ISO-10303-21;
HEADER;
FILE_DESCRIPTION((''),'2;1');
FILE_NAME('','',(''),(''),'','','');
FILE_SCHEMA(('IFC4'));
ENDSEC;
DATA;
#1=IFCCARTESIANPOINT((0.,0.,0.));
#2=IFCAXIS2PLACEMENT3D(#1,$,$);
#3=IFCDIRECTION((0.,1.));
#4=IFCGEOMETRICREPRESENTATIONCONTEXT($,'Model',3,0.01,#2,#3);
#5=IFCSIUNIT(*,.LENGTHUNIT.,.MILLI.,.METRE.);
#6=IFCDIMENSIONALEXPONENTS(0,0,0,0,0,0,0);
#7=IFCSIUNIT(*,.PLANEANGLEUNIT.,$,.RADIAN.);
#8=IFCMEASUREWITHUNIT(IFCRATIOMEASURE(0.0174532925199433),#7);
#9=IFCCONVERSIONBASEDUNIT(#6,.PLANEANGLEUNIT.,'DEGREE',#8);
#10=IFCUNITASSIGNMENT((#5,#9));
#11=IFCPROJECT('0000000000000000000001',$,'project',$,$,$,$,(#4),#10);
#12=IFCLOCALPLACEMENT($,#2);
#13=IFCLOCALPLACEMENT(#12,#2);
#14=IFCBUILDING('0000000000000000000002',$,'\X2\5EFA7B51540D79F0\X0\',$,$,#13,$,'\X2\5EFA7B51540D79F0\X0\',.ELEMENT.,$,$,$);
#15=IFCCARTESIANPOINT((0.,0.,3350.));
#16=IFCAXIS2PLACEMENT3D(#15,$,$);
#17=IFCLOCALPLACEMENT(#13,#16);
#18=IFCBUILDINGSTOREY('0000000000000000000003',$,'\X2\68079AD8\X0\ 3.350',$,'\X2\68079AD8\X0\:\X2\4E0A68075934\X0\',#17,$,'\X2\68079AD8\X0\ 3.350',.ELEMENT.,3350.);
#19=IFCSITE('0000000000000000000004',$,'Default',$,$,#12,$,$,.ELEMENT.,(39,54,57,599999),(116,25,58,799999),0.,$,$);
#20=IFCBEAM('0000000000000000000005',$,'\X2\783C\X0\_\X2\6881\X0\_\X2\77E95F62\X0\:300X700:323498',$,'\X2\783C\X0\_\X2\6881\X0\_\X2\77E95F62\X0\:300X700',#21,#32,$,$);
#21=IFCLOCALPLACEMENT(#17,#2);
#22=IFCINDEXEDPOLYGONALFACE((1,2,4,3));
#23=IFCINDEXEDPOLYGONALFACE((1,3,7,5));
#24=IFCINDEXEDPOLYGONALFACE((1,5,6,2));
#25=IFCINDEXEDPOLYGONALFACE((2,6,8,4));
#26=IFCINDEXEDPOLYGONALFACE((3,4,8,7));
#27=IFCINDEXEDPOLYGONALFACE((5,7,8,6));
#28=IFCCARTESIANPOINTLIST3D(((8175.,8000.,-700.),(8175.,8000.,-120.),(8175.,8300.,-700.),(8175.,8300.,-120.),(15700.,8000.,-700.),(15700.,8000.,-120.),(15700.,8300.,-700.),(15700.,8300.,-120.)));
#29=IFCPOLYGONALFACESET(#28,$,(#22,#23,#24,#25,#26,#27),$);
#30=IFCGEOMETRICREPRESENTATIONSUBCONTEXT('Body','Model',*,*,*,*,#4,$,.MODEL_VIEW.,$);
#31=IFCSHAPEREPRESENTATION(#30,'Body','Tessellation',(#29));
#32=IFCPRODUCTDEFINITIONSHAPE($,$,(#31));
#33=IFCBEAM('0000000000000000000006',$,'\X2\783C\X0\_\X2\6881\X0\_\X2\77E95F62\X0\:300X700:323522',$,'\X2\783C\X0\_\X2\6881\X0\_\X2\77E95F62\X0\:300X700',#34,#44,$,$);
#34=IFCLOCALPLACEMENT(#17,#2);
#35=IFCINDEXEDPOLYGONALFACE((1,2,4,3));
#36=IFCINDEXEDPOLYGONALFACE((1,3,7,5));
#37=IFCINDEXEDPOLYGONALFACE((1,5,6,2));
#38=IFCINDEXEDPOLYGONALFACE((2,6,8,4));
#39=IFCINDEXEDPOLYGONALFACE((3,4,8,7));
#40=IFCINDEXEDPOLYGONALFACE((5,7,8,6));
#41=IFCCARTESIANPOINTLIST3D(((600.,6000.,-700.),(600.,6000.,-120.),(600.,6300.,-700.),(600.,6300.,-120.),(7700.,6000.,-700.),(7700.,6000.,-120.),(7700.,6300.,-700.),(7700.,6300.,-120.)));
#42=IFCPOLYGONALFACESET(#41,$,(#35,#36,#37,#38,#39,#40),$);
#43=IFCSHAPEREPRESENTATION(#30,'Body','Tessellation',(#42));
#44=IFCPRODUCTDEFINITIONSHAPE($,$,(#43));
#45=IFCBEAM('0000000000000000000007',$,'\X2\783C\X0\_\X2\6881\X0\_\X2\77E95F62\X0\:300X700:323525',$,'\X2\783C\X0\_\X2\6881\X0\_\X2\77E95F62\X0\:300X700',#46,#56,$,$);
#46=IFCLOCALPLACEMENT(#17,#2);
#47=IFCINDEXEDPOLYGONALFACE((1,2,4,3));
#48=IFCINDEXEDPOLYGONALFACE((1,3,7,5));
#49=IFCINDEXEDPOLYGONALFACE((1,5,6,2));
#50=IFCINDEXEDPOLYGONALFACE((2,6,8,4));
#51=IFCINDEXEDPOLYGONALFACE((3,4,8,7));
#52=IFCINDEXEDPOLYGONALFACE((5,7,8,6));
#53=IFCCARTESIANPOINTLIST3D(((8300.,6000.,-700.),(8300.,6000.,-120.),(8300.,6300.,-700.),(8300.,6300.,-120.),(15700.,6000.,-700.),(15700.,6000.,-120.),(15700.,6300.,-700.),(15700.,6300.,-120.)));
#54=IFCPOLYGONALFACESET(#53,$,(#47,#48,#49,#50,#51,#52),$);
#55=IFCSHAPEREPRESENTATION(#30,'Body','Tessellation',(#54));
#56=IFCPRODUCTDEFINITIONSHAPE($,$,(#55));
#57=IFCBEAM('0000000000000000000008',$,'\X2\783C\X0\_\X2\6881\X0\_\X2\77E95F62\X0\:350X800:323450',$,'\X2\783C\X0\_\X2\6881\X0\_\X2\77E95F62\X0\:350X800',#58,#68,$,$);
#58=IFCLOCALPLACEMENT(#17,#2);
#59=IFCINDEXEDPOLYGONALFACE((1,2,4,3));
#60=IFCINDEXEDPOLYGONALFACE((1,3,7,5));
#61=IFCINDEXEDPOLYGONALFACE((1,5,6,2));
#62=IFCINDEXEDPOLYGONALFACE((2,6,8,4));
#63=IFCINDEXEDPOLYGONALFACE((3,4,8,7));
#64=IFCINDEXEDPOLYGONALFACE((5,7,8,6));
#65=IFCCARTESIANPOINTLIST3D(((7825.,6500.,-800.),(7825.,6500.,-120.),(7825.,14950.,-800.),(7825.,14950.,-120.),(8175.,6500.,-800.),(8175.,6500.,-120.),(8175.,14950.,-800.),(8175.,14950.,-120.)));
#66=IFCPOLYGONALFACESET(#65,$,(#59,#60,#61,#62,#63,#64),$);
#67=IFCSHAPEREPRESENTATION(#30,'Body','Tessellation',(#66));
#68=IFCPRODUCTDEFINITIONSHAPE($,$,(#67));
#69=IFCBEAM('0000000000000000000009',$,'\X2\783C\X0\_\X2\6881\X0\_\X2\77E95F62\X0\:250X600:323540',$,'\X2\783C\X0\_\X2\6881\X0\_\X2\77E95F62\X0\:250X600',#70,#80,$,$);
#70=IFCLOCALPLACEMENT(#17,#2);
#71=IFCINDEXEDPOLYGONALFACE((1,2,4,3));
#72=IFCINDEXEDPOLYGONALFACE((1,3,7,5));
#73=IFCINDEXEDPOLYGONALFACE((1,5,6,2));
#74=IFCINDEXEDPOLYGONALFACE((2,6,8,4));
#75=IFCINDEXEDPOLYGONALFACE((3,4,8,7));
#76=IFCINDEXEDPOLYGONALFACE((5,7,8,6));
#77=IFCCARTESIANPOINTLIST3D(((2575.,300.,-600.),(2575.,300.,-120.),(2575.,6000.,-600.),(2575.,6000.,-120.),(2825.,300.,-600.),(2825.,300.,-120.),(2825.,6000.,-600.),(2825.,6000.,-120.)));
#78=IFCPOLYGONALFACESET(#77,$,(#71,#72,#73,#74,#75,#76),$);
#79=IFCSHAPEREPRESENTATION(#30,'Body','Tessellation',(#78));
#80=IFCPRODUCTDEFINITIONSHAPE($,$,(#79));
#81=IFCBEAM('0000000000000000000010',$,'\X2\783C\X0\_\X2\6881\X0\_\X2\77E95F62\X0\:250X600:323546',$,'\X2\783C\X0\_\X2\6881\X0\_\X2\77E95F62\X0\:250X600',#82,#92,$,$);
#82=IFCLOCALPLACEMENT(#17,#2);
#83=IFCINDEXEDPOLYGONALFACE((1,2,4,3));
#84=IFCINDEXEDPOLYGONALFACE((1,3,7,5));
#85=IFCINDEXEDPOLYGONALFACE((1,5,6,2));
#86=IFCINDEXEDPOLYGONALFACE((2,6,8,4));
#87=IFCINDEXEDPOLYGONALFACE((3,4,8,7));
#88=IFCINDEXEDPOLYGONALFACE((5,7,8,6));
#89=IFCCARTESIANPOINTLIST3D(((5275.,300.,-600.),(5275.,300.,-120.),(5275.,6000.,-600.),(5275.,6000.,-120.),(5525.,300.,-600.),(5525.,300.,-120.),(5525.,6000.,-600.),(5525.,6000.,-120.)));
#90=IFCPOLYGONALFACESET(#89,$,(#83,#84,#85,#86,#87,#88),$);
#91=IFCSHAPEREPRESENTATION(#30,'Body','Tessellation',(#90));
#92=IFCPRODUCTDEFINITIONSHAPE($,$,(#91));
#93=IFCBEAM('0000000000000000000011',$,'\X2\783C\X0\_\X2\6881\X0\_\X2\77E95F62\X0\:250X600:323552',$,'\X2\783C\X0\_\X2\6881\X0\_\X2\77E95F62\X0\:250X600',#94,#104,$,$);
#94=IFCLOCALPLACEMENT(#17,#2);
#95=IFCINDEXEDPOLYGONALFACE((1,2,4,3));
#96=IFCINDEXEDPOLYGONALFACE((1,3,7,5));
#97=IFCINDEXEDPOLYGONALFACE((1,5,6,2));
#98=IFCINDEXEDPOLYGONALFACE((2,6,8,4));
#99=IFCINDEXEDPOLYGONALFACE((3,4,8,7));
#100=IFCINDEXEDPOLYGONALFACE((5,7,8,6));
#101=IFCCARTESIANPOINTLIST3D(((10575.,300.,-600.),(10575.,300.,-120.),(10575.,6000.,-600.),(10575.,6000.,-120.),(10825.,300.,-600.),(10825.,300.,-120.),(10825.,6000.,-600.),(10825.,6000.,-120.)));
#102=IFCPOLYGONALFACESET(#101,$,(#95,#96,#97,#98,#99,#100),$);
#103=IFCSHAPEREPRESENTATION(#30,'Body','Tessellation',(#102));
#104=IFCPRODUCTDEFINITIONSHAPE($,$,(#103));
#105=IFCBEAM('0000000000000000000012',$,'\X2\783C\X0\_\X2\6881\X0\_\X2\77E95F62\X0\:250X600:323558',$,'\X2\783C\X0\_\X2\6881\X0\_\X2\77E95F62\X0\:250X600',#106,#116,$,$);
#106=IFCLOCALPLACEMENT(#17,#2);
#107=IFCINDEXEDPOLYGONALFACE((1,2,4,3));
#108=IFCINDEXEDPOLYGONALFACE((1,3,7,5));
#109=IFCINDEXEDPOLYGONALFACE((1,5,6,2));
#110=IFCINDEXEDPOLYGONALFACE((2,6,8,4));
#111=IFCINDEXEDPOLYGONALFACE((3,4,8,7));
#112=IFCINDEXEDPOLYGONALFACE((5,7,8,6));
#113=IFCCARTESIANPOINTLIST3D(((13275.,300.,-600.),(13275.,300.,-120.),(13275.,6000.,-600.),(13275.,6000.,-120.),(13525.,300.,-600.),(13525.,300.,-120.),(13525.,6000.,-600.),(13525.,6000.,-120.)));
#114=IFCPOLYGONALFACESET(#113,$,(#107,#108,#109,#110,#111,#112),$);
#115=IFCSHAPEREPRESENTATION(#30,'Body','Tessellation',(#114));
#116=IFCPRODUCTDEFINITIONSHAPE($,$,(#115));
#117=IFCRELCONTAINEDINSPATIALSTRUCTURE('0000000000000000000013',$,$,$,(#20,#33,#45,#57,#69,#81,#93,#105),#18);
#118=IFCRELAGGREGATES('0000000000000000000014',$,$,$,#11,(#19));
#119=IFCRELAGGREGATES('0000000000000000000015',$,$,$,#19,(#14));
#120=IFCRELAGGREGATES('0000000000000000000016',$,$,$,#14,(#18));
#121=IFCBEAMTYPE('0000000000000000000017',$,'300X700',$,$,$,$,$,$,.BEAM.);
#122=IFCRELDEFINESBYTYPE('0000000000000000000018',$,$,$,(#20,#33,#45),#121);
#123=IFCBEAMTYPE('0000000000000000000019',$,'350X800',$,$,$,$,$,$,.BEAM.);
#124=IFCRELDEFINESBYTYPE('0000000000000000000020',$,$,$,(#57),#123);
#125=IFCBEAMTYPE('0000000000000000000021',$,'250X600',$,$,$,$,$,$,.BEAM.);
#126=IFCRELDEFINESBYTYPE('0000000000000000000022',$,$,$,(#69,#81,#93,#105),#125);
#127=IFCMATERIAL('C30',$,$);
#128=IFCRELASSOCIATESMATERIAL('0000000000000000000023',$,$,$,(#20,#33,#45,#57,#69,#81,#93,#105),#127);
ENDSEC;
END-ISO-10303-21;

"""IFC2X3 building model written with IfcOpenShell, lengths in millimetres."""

from ifc_helpers import new_model, entity, si_unit, converted_unit, direction, frame, frame_2d, origin, place, context, subcontext, project, spatial, rectangle, extrude, material, type_object, element, save


model = new_model("IFC2X3")

# Units and contexts
model_context = context("Model", 3, precision=0.01, world=origin(), true_north=direction((0.0, 1.0)))
body_context = subcontext(model_context, "Body", "Model", "MODEL_VIEW")
ifc_project = project(units=[si_unit("LENGTHUNIT", "METRE", prefix="MILLI"), converted_unit("PLANEANGLEUNIT", "DEGREE", entity("IfcRatioMeasure", 0.0174532925199433), si_unit("PLANEANGLEUNIT", "RADIAN"), dimensions=[0, 0, 0, 0, 0, 0, 0])], contexts=[model_context])

# Site, building, storey
site_placement = place(None, origin())
site = spatial("IfcSite", under=ifc_project, at=site_placement, Name="Default", CompositionType="ELEMENT", RefLatitude=(39, 54, 57, 599999), RefLongitude=(116, 25, 58, 799999), RefElevation=0.0)
building_placement = place(site_placement, origin())
building = spatial("IfcBuilding", under=site, at=building_placement, Name="建筑名称", LongName="建筑名称", CompositionType="ELEMENT")
storey_placement = place(building_placement, frame((0.0, 0.0, 3350.0)))
storey = spatial("IfcBuildingStorey", under=building, at=storey_placement, Name="标高 3.350", ObjectType="标高:上标头", LongName="标高 3.350", CompositionType="ELEMENT", Elevation=3350.0)

# Shared definitions
ifc_material = material(Name="C30")

# Beams
beam_type_1 = type_object("IfcBeamType", Name="300X700", PredefinedType="BEAM")
beam_1_placement = place(storey_placement, frame((8000.0, 8150.0, 0.0)))
element("IfcBeam", 1, at=beam_1_placement, inside=storey, type_object=beam_type_1, material=ifc_material, Name="砼_梁_矩形:300X700:323498", ObjectType="砼_梁_矩形:300X700", context=body_context, shape_type="SweptSolid", body=[
    extrude(rectangle(XDim=580.0, YDim=300.0, at=frame_2d((0.0, 0.0), x_axis=(1.0, 0.0))), frame((175.0, 0.0, -410.0), z_axis=(1.0, 0.0, 0.0), x_axis=(0.0, 0.0, -1.0)), (0.0, 0.0, 1.0), 7525.0),
])
beam_2_placement = place(storey_placement, frame((150.0, 6150.0, 0.0)))
element("IfcBeam", 2, at=beam_2_placement, inside=storey, type_object=beam_type_1, material=ifc_material, Name="砼_梁_矩形:300X700:323522", ObjectType="砼_梁_矩形:300X700", context=body_context, shape_type="SweptSolid", body=[
    extrude(rectangle(XDim=580.0, YDim=300.0, at=frame_2d((0.0, 0.0), x_axis=(1.0, 0.0))), frame((450.0, 0.0, -410.0), z_axis=(1.0, 0.0, 0.0), x_axis=(0.0, 0.0, -1.0)), (0.0, 0.0, 1.0), 7100.0),
])
beam_3_placement = place(storey_placement, frame((8000.0, 6150.0, 0.0)))
element("IfcBeam", 3, at=beam_3_placement, inside=storey, type_object=beam_type_1, material=ifc_material, Name="砼_梁_矩形:300X700:323525", ObjectType="砼_梁_矩形:300X700", context=body_context, shape_type="SweptSolid", body=[
    extrude(rectangle(XDim=580.0, YDim=300.0, at=frame_2d((0.0, 0.0), x_axis=(1.0, 0.0))), frame((300.0, 0.0, -410.0), z_axis=(1.0, 0.0, 0.0), x_axis=(0.0, 0.0, -1.0)), (0.0, 0.0, 1.0), 7400.0),
])
beam_type_2 = type_object("IfcBeamType", Name="350X800", PredefinedType="BEAM")
beam_4_placement = place(storey_placement, frame((8000.0, 6150.0, 0.0), z_axis=(0.0, 0.0, 1.0), x_axis=(0.0, 1.0, 0.0)))
element("IfcBeam", 4, at=beam_4_placement, inside=storey, type_object=beam_type_2, material=ifc_material, Name="砼_梁_矩形:350X800:323450", ObjectType="砼_梁_矩形:350X800", context=body_context, shape_type="SweptSolid", body=[
    extrude(rectangle(XDim=680.0, YDim=350.0, at=frame_2d((0.0, 0.0), x_axis=(1.0, 0.0))), frame((350.0, 0.0, -460.0), z_axis=(1.0, 0.0, 0.0), x_axis=(0.0, 0.0, -1.0)), (0.0, 0.0, 1.0), 8450.0),
])
beam_type_3 = type_object("IfcBeamType", Name="250X600", PredefinedType="BEAM")
beam_5_placement = place(storey_placement, frame((2700.0, 0.0, 0.0), z_axis=(0.0, 0.0, 1.0), x_axis=(0.0, 1.0, 0.0)))
element("IfcBeam", 5, at=beam_5_placement, inside=storey, type_object=beam_type_3, material=ifc_material, Name="砼_梁_矩形:250X600:323540", ObjectType="砼_梁_矩形:250X600", context=body_context, shape_type="SweptSolid", body=[
    extrude(rectangle(XDim=480.0, YDim=250.0, at=frame_2d((0.0, 0.0), x_axis=(1.0, 0.0))), frame((300.0, 0.0, -360.0), z_axis=(1.0, 0.0, 0.0), x_axis=(0.0, 0.0, -1.0)), (0.0, 0.0, 1.0), 5700.0),
])
beam_6_placement = place(storey_placement, frame((5400.0, 0.0, 0.0), z_axis=(0.0, 0.0, 1.0), x_axis=(0.0, 1.0, 0.0)))
element("IfcBeam", 6, at=beam_6_placement, inside=storey, type_object=beam_type_3, material=ifc_material, Name="砼_梁_矩形:250X600:323546", ObjectType="砼_梁_矩形:250X600", context=body_context, shape_type="SweptSolid", body=[
    extrude(rectangle(XDim=480.0, YDim=250.0, at=frame_2d((0.0, 0.0), x_axis=(1.0, 0.0))), frame((300.0, 0.0, -360.0), z_axis=(1.0, 0.0, 0.0), x_axis=(0.0, 0.0, -1.0)), (0.0, 0.0, 1.0), 5700.0),
])
beam_7_placement = place(storey_placement, frame((10700.0, 0.0, 0.0), z_axis=(0.0, 0.0, 1.0), x_axis=(0.0, 1.0, 0.0)))
element("IfcBeam", 7, at=beam_7_placement, inside=storey, type_object=beam_type_3, material=ifc_material, Name="砼_梁_矩形:250X600:323552", ObjectType="砼_梁_矩形:250X600", context=body_context, shape_type="SweptSolid", body=[
    extrude(rectangle(XDim=480.0, YDim=250.0, at=frame_2d((0.0, 0.0), x_axis=(1.0, 0.0))), frame((300.0, 0.0, -360.0), z_axis=(1.0, 0.0, 0.0), x_axis=(0.0, 0.0, -1.0)), (0.0, 0.0, 1.0), 5700.0),
])
beam_8_placement = place(storey_placement, frame((13400.0, 0.0, 0.0), z_axis=(0.0, 0.0, 1.0), x_axis=(0.0, 1.0, 0.0)))
element("IfcBeam", 8, at=beam_8_placement, inside=storey, type_object=beam_type_3, material=ifc_material, Name="砼_梁_矩形:250X600:323558", ObjectType="砼_梁_矩形:250X600", context=body_context, shape_type="SweptSolid", body=[
    extrude(rectangle(XDim=480.0, YDim=250.0, at=frame_2d((0.0, 0.0), x_axis=(1.0, 0.0))), frame((300.0, 0.0, -360.0), z_axis=(1.0, 0.0, 0.0), x_axis=(0.0, 0.0, -1.0)), (0.0, 0.0, 1.0), 5700.0),
])

save(model, "model.ifc")
